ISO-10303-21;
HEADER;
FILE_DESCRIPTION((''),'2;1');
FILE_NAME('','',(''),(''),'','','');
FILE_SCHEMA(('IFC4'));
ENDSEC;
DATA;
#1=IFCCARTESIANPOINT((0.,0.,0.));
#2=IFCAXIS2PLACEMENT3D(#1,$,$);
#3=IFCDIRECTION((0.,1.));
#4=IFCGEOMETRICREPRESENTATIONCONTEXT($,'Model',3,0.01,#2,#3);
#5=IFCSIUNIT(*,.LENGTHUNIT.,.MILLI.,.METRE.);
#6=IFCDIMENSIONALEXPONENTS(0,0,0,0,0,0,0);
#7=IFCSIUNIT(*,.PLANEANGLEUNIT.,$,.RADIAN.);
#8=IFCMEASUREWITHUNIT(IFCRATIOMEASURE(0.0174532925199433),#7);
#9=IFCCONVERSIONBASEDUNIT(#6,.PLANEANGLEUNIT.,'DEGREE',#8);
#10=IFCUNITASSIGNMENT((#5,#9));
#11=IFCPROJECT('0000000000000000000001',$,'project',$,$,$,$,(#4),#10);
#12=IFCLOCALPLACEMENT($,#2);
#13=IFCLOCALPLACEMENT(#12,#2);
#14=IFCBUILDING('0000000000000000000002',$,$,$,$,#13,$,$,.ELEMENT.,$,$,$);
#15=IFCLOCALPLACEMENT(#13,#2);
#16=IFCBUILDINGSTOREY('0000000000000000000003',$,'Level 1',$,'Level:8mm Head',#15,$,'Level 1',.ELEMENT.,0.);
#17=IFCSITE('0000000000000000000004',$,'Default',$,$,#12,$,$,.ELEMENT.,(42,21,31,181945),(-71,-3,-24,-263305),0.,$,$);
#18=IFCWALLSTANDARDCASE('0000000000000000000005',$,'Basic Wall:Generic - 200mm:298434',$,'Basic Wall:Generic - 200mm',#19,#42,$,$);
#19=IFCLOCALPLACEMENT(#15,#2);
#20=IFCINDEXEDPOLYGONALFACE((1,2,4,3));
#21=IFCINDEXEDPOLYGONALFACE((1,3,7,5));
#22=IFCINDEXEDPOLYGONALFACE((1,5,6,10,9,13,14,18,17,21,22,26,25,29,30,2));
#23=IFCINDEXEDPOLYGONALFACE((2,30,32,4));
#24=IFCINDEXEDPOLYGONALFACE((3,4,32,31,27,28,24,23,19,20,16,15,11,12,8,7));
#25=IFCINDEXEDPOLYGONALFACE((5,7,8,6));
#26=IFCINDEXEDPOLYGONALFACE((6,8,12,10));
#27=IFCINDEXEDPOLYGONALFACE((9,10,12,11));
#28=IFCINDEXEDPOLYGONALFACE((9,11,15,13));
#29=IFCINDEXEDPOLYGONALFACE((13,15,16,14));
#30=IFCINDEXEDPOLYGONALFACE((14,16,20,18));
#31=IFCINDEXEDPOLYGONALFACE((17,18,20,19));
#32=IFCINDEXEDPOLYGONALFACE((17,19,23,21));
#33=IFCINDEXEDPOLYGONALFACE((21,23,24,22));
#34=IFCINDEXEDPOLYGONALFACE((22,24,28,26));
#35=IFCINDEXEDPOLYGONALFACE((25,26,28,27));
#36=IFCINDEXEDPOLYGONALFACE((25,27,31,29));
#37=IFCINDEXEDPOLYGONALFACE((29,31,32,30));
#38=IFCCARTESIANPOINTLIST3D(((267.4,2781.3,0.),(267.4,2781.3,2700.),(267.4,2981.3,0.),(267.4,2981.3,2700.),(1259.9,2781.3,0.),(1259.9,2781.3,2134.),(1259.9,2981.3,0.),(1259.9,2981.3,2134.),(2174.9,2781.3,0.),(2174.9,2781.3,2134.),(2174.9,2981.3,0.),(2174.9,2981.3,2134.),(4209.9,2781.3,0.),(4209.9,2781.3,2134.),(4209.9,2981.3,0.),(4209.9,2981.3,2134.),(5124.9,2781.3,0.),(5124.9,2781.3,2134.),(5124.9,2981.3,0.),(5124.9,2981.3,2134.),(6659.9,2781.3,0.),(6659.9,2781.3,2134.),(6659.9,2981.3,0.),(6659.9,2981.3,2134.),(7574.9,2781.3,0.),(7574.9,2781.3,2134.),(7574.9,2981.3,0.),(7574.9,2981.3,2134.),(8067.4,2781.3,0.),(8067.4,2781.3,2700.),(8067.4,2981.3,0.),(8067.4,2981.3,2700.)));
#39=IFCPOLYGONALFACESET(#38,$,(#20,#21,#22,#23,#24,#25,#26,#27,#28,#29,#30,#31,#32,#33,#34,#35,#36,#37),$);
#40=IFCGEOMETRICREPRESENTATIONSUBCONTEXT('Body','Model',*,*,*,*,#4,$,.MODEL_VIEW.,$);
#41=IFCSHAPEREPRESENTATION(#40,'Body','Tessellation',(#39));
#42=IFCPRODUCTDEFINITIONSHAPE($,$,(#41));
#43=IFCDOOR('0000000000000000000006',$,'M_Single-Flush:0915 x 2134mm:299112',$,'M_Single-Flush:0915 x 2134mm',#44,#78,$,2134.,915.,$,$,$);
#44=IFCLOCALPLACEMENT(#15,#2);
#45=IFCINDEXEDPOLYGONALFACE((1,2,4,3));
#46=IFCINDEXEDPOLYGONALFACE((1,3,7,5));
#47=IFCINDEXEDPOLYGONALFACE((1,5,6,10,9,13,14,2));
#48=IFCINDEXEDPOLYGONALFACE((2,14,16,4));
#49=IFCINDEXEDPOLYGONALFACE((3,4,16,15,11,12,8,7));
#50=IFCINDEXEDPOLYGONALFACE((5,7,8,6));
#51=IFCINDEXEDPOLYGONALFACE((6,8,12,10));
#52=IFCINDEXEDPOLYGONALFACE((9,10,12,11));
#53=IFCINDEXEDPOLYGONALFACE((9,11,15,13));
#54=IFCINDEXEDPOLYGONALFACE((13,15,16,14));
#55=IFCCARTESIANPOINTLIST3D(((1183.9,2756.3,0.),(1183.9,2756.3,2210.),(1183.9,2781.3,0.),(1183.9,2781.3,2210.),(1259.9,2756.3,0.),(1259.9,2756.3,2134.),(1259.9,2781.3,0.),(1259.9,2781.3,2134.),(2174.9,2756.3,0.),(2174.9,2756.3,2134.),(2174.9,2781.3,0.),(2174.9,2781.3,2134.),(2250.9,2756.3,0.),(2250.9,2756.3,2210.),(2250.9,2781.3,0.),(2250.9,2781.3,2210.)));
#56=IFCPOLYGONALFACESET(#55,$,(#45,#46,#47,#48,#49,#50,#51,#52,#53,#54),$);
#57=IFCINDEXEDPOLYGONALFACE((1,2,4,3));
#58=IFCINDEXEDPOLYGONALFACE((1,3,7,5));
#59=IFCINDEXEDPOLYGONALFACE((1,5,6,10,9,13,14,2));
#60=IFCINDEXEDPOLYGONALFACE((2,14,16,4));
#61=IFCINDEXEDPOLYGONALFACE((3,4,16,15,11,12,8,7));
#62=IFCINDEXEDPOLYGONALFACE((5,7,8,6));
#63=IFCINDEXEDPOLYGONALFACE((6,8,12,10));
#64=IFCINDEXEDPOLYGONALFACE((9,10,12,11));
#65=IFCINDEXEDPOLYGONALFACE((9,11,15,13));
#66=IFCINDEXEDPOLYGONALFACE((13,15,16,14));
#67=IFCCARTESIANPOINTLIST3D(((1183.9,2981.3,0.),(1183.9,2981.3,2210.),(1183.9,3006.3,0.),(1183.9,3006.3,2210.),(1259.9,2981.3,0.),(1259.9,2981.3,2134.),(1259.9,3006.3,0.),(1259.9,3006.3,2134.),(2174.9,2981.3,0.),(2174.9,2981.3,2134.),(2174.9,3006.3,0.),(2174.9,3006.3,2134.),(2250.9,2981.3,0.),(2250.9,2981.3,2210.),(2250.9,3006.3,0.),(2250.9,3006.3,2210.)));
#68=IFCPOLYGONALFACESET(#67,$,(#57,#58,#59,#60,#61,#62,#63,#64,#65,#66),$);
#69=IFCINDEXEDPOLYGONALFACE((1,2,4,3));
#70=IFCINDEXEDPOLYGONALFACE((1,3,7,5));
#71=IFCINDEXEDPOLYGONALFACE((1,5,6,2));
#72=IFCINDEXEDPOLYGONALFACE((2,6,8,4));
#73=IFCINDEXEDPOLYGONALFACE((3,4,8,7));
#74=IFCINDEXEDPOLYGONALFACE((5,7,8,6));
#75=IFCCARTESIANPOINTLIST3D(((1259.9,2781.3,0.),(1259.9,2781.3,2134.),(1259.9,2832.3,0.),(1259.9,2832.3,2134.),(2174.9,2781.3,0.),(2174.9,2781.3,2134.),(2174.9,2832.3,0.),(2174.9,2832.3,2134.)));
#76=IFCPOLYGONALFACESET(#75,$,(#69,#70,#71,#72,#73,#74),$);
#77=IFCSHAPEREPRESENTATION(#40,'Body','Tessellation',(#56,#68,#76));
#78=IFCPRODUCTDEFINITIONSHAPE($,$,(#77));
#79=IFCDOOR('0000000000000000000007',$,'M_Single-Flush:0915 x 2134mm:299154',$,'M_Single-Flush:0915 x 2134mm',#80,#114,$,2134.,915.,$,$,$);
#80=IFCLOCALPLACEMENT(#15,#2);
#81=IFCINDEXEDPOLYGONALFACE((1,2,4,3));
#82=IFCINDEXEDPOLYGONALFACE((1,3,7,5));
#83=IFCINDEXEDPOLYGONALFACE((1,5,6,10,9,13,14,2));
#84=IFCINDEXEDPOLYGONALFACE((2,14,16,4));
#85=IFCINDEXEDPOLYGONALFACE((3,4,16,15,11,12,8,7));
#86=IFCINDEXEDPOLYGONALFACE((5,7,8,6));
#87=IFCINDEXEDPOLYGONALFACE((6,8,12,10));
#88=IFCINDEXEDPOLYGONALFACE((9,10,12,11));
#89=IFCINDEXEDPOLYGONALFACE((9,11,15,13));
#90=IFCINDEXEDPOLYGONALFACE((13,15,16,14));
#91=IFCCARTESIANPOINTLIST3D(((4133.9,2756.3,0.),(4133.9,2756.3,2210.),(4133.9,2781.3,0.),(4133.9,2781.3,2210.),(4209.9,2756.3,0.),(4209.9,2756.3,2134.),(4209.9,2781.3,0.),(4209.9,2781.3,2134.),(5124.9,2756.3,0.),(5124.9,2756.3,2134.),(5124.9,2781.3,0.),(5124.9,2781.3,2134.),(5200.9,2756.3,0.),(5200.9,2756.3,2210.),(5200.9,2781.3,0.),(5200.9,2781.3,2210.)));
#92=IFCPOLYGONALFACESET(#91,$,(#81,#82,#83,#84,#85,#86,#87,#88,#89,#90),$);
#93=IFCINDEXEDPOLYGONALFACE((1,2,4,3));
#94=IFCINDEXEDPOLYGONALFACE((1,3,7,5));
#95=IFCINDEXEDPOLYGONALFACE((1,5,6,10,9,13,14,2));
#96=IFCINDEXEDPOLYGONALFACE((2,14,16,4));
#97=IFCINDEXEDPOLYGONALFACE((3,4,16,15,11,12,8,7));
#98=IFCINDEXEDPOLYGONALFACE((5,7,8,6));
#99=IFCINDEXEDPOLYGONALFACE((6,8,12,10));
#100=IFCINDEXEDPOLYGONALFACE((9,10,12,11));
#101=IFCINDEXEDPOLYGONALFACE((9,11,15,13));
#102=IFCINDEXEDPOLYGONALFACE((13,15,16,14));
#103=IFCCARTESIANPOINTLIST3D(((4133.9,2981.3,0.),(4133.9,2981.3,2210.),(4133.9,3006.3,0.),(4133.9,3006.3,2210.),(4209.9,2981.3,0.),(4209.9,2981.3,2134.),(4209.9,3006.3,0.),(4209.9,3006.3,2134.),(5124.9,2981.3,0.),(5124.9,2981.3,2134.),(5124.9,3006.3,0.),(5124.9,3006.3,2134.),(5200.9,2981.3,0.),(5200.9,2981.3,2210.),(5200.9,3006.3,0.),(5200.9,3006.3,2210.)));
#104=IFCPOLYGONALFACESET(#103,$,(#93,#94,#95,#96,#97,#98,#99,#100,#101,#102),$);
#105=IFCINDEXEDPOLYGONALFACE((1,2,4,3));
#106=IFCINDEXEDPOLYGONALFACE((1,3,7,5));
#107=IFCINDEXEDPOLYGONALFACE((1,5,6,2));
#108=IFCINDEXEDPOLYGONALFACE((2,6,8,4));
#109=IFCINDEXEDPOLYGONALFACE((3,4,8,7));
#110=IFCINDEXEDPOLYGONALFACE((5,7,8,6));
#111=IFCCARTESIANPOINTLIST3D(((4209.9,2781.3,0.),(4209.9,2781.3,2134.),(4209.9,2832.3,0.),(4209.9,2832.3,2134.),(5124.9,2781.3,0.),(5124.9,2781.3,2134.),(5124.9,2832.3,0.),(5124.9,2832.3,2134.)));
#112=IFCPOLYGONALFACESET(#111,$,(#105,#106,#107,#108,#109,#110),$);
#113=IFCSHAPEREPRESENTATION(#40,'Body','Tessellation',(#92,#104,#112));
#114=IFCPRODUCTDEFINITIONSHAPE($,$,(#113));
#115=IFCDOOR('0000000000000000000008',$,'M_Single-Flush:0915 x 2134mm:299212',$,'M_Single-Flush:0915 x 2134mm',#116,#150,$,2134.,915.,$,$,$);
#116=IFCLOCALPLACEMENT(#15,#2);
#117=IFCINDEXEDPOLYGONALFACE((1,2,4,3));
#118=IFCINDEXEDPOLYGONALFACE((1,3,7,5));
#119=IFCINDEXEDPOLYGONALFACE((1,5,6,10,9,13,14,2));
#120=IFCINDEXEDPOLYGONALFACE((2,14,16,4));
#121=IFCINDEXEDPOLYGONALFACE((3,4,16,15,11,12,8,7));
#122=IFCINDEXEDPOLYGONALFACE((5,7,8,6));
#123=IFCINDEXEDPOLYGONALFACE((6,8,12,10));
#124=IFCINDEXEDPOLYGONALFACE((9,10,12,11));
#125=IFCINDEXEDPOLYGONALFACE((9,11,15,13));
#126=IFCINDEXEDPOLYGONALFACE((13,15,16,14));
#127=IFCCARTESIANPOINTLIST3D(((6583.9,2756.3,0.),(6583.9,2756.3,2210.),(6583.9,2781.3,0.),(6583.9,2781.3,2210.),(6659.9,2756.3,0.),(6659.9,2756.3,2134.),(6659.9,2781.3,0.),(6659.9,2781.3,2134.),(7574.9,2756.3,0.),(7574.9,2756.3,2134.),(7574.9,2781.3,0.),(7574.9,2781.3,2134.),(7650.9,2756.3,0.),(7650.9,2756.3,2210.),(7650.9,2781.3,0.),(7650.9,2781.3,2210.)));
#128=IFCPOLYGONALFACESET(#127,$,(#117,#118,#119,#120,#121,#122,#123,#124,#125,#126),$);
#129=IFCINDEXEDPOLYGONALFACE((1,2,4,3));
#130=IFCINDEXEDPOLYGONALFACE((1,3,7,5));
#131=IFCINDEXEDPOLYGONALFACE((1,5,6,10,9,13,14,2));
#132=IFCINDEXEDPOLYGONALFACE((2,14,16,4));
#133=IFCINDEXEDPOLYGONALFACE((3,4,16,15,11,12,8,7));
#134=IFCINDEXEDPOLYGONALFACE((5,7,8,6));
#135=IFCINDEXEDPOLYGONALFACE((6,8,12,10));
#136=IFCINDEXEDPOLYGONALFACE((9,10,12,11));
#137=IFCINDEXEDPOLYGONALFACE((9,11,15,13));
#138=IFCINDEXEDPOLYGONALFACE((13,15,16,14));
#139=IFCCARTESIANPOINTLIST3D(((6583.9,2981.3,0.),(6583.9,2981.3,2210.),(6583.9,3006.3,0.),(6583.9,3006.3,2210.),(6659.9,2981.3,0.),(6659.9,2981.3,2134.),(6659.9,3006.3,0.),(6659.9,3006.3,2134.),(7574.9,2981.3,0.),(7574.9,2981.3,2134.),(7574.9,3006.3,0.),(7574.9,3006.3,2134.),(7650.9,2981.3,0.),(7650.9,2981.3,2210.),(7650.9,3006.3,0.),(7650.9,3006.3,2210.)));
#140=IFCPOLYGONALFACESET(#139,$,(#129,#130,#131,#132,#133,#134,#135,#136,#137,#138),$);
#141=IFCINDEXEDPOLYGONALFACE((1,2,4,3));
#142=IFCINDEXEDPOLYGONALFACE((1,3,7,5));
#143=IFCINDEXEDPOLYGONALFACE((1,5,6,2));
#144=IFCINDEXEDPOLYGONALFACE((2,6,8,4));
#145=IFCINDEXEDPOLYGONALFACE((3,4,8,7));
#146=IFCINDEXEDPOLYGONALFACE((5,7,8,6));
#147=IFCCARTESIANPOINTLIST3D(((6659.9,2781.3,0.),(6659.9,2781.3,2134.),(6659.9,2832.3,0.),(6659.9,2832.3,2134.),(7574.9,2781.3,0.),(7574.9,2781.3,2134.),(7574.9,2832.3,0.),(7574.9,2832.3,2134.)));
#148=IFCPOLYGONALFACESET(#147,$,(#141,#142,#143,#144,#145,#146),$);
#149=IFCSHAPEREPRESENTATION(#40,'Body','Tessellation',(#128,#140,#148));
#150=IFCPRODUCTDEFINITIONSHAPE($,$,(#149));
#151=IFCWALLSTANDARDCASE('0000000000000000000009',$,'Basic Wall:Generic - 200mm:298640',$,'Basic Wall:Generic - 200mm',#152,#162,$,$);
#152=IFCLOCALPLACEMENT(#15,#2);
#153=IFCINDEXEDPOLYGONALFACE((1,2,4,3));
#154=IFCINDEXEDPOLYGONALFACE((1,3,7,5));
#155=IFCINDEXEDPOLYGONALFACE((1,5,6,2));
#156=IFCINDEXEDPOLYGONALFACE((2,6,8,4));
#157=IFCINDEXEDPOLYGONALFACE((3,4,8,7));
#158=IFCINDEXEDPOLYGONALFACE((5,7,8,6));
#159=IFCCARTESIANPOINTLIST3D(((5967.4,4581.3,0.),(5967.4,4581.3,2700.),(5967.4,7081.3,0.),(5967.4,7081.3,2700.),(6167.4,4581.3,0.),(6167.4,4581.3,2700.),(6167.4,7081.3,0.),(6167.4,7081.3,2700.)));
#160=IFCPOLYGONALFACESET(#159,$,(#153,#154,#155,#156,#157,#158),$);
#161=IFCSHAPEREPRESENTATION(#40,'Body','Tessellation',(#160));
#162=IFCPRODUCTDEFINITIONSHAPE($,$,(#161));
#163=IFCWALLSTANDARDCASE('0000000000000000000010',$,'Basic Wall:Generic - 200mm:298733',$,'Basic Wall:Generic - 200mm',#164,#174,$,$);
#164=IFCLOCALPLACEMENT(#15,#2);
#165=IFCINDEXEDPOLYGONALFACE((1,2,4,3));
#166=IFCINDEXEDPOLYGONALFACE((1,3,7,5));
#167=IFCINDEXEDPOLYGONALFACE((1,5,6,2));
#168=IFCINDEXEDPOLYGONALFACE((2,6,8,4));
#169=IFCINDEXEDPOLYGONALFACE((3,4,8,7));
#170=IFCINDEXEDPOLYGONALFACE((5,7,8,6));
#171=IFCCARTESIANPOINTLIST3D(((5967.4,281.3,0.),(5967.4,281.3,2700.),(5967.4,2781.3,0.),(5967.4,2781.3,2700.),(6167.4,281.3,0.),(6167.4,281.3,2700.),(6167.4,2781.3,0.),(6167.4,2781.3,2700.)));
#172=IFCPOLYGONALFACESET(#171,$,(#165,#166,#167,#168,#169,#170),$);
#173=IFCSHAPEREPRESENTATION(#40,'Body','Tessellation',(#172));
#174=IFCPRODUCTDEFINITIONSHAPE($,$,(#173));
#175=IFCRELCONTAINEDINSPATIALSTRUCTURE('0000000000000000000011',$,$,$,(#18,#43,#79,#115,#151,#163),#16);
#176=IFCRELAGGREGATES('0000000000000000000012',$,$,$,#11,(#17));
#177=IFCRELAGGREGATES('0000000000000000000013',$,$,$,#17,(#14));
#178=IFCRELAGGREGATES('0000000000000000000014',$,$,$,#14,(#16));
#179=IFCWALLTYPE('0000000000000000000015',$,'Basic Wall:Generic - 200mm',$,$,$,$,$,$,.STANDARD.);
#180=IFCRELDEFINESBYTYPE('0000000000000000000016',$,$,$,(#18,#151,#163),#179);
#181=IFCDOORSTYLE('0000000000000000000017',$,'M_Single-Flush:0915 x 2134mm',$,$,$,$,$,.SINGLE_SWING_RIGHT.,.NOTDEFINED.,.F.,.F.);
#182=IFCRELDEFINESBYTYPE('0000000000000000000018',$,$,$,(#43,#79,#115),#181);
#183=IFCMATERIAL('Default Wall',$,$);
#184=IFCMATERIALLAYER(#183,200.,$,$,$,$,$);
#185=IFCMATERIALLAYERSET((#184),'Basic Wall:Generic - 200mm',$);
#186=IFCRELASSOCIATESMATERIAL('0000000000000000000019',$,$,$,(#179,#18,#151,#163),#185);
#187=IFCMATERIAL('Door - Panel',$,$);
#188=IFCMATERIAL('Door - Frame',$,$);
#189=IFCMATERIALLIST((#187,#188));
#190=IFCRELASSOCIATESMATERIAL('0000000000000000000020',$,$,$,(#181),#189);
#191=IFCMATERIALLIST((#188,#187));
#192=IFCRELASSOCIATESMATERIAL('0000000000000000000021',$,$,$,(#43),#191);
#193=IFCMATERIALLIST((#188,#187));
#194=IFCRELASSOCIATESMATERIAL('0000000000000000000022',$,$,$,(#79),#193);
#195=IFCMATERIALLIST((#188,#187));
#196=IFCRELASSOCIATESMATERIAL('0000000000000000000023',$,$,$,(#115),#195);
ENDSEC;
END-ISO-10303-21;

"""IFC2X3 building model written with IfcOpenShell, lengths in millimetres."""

from ifc_helpers import new_model, entity, si_unit, converted_unit, direction, frame, frame_2d, origin, place, context, subcontext, project, spatial, polyline, rectangle, outline, extrude, source, transform, mapped, material, material_list, layer, layer_set, layer_usage, type_object, type_shapes, element, fill, save


model = new_model("IFC2X3")

# Units and contexts
model_context = context("Model", 3, precision=0.01, world=origin(), true_north=direction((0.0, 1.0)))
body_context = subcontext(model_context, "Body", "Model", "MODEL_VIEW")
ifc_project = project(units=[si_unit("LENGTHUNIT", "METRE", prefix="MILLI"), converted_unit("PLANEANGLEUNIT", "DEGREE", entity("IfcRatioMeasure", 0.0174532925199433), si_unit("PLANEANGLEUNIT", "RADIAN"), dimensions=[0, 0, 0, 0, 0, 0, 0])], contexts=[model_context])

# Site, building, storey
site_placement = place(None, origin())
site = spatial("IfcSite", under=ifc_project, at=site_placement, Name="Default", CompositionType="ELEMENT", RefLatitude=(42, 21, 31, 181945), RefLongitude=(-71, -3, -24, -263305), RefElevation=0.0)
building_placement = place(site_placement, origin())
building = spatial("IfcBuilding", under=site, at=building_placement, CompositionType="ELEMENT")
storey_placement = place(building_placement, origin())
storey = spatial("IfcBuildingStorey", under=building, at=storey_placement, Name="Level 1", ObjectType="Level:8mm Head", LongName="Level 1", CompositionType="ELEMENT", Elevation=0.0)

# Shared definitions
ifc_material_1 = material(Name="Default Wall")
ifc_layer = layer(ifc_material_1, 200.0)
ifc_layer_set = layer_set([ifc_layer], Name="Basic Wall:Generic - 200mm")
wall_type = type_object("IfcWallType", Name="Basic Wall:Generic - 200mm", PredefinedType="STANDARD", material=ifc_layer_set)

# Wall, openings, doors
ifc_layer_usage_1 = layer_usage(ifc_layer_set, "AXIS2", "NEGATIVE", 100.0)
wall_1_placement = place(storey_placement, frame((8067.4, 2881.3, 0.0), z_axis=(0.0, 0.0, 1.0), x_axis=(-1.0, 0.0, 0.0)))
wall_1 = element("IfcWallStandardCase", 1, at=wall_1_placement, inside=storey, type_object=wall_type, material=ifc_layer_usage_1, Name="Basic Wall:Generic - 200mm:298434", ObjectType="Basic Wall:Generic - 200mm", context=body_context, shape_type="SweptSolid", body=[
    extrude(rectangle(XDim=7800.0, YDim=200.0, at=frame_2d((3900.0, 0.0), x_axis=(-1.0, 0.0))), origin(), (0.0, 0.0, 1.0), 2700.0),
])
opening_1_placement = place(wall_1_placement, frame((5892.5, -100.0, 0.0)))
opening_1 = element("IfcOpeningElement", 2, at=opening_1_placement, cuts=wall_1, ObjectType="Opening", context=body_context, shape_type="SweptSolid", body=[
    extrude(rectangle(XDim=915.0, YDim=2134.0, at=frame_2d((1067.0, 457.5), x_axis=(0.0, 1.0))), frame((0.0, 0.0, 0.0), z_axis=(0.0, 1.0, 0.0), x_axis=(0.0, 0.0, 1.0)), (0.0, 0.0, 1.0), 200.0),
])
opening_2_placement = place(wall_1_placement, frame((2942.5, -100.0, 0.0)))
opening_2 = element("IfcOpeningElement", 3, at=opening_2_placement, cuts=wall_1, ObjectType="Opening", context=body_context, shape_type="SweptSolid", body=[
    extrude(rectangle(XDim=915.0, YDim=2134.0, at=frame_2d((1067.0, 457.5), x_axis=(0.0, 1.0))), frame((0.0, 0.0, 0.0), z_axis=(0.0, 1.0, 0.0), x_axis=(0.0, 0.0, 1.0)), (0.0, 0.0, 1.0), 200.0),
])
opening_3_placement = place(wall_1_placement, frame((492.5, -100.0, 0.0)))
opening_3 = element("IfcOpeningElement", 4, at=opening_3_placement, cuts=wall_1, ObjectType="Opening", context=body_context, shape_type="SweptSolid", body=[
    extrude(rectangle(XDim=915.0, YDim=2134.0, at=frame_2d((1067.0, 457.5), x_axis=(0.0, 1.0))), frame((0.0, 0.0, 0.0), z_axis=(0.0, 1.0, 0.0), x_axis=(0.0, 0.0, 1.0)), (0.0, 0.0, 1.0), 200.0),
])
ifc_material_2 = material(Name="Door - Frame")
ifc_material_3 = material(Name="Door - Panel")
ifc_material_list_1 = material_list([ifc_material_2, ifc_material_3])
ifc_material_list_2 = material_list([ifc_material_3, ifc_material_2])
door_style = type_object("IfcDoorStyle", Name="M_Single-Flush:0915 x 2134mm", ConstructionType="NOTDEFINED", OperationType="SINGLE_SWING_RIGHT", ParameterTakesPrecedence=False, Sizeable=False, material=ifc_material_list_2)
shared_shape_1 = source(origin(), body_context, "Body", "SweptSolid", [
    extrude(outline(polyline([(-533.5, -1124.0), (533.5, -1124.0), (533.5, 1086.0), (457.5, 1086.0), (457.5, -1048.0), (-457.5, -1048.0), (-457.5, 1086.0), (-533.5, 1086.0), (-533.5, -1124.0)])), frame((457.5, 200.0, 1086.0), z_axis=(0.0, 1.0, 0.0), x_axis=(1.0, 0.0, 0.0)), (0.0, 0.0, 1.0), 25.0),
    extrude(outline(polyline([(-1124.0, -533.5), (1086.0, -533.5), (1086.0, -457.5), (-1048.0, -457.5), (-1048.0, 457.5), (1086.0, 457.5), (1086.0, 533.5), (-1124.0, 533.5), (-1124.0, -533.5)])), frame((457.5, -25.0, 1086.0), z_axis=(0.0, 1.0, 0.0), x_axis=(0.0, 0.0, -1.0)), (0.0, 0.0, 1.0), 25.0),
    extrude(rectangle(XDim=51.0, YDim=915.0, at=frame_2d((0.0, 0.0), x_axis=(1.0, 0.0))), frame((457.5, 174.5, 0.0), z_axis=(0.0, 0.0, 1.0), x_axis=(0.0, 1.0, 0.0)), (0.0, 0.0, 1.0), 2134.0),
])
type_shapes(door_style, [shared_shape_1])
door_1_placement = place(opening_1_placement, origin())
door_1 = element("IfcDoor", 5, at=door_1_placement, inside=storey, type_object=door_style, material=ifc_material_list_1, Name="M_Single-Flush:0915 x 2134mm:299112", ObjectType="M_Single-Flush:0915 x 2134mm", OverallHeight=2134.0, OverallWidth=915.0, context=body_context, shape_type="MappedRepresentation", body=[
    mapped(shared_shape_1, transform((0.0, 0.0, 0.0), scale=1.0)),
])
fill(opening_1, door_1)
ifc_material_list_3 = material_list([ifc_material_2, ifc_material_3])
door_2_placement = place(opening_2_placement, origin())
door_2 = element("IfcDoor", 6, at=door_2_placement, inside=storey, type_object=door_style, material=ifc_material_list_3, Name="M_Single-Flush:0915 x 2134mm:299154", ObjectType="M_Single-Flush:0915 x 2134mm", OverallHeight=2134.0, OverallWidth=915.0, context=body_context, shape_type="MappedRepresentation", body=[
    mapped(shared_shape_1, transform((0.0, 0.0, 0.0), scale=1.0)),
])
fill(opening_2, door_2)
ifc_material_list_4 = material_list([ifc_material_2, ifc_material_3])
door_3_placement = place(opening_3_placement, origin())
door_3 = element("IfcDoor", 7, at=door_3_placement, inside=storey, type_object=door_style, material=ifc_material_list_4, Name="M_Single-Flush:0915 x 2134mm:299212", ObjectType="M_Single-Flush:0915 x 2134mm", OverallHeight=2134.0, OverallWidth=915.0, context=body_context, shape_type="MappedRepresentation", body=[
    mapped(shared_shape_1, transform((0.0, 0.0, 0.0), scale=1.0)),
])
fill(opening_3, door_3)

# Walls
ifc_layer_usage_2 = layer_usage(ifc_layer_set, "AXIS2", "NEGATIVE", 100.0)
wall_2_placement = place(storey_placement, frame((6067.4, 7081.3, 0.0), z_axis=(0.0, 0.0, 1.0), x_axis=(0.0, -1.0, 0.0)))
element("IfcWallStandardCase", 8, at=wall_2_placement, inside=storey, type_object=wall_type, material=ifc_layer_usage_2, Name="Basic Wall:Generic - 200mm:298640", ObjectType="Basic Wall:Generic - 200mm", context=body_context, shape_type="SweptSolid", body=[
    extrude(rectangle(XDim=2500.0, YDim=200.0, at=frame_2d((1250.0, 0.0), x_axis=(-1.0, 0.0))), origin(), (0.0, 0.0, 1.0), 2700.0),
])
ifc_layer_usage_3 = layer_usage(ifc_layer_set, "AXIS2", "NEGATIVE", 100.0)
wall_3_placement = place(storey_placement, frame((6067.4, 2781.3, 0.0), z_axis=(0.0, 0.0, 1.0), x_axis=(0.0, -1.0, 0.0)))
element("IfcWallStandardCase", 9, at=wall_3_placement, inside=storey, type_object=wall_type, material=ifc_layer_usage_3, Name="Basic Wall:Generic - 200mm:298733", ObjectType="Basic Wall:Generic - 200mm", context=body_context, shape_type="SweptSolid", body=[
    extrude(rectangle(XDim=2500.0, YDim=200.0, at=frame_2d((1250.0, 0.0), x_axis=(-1.0, 0.0))), origin(), (0.0, 0.0, 1.0), 2700.0),
])

save(model, "model.ifc")
